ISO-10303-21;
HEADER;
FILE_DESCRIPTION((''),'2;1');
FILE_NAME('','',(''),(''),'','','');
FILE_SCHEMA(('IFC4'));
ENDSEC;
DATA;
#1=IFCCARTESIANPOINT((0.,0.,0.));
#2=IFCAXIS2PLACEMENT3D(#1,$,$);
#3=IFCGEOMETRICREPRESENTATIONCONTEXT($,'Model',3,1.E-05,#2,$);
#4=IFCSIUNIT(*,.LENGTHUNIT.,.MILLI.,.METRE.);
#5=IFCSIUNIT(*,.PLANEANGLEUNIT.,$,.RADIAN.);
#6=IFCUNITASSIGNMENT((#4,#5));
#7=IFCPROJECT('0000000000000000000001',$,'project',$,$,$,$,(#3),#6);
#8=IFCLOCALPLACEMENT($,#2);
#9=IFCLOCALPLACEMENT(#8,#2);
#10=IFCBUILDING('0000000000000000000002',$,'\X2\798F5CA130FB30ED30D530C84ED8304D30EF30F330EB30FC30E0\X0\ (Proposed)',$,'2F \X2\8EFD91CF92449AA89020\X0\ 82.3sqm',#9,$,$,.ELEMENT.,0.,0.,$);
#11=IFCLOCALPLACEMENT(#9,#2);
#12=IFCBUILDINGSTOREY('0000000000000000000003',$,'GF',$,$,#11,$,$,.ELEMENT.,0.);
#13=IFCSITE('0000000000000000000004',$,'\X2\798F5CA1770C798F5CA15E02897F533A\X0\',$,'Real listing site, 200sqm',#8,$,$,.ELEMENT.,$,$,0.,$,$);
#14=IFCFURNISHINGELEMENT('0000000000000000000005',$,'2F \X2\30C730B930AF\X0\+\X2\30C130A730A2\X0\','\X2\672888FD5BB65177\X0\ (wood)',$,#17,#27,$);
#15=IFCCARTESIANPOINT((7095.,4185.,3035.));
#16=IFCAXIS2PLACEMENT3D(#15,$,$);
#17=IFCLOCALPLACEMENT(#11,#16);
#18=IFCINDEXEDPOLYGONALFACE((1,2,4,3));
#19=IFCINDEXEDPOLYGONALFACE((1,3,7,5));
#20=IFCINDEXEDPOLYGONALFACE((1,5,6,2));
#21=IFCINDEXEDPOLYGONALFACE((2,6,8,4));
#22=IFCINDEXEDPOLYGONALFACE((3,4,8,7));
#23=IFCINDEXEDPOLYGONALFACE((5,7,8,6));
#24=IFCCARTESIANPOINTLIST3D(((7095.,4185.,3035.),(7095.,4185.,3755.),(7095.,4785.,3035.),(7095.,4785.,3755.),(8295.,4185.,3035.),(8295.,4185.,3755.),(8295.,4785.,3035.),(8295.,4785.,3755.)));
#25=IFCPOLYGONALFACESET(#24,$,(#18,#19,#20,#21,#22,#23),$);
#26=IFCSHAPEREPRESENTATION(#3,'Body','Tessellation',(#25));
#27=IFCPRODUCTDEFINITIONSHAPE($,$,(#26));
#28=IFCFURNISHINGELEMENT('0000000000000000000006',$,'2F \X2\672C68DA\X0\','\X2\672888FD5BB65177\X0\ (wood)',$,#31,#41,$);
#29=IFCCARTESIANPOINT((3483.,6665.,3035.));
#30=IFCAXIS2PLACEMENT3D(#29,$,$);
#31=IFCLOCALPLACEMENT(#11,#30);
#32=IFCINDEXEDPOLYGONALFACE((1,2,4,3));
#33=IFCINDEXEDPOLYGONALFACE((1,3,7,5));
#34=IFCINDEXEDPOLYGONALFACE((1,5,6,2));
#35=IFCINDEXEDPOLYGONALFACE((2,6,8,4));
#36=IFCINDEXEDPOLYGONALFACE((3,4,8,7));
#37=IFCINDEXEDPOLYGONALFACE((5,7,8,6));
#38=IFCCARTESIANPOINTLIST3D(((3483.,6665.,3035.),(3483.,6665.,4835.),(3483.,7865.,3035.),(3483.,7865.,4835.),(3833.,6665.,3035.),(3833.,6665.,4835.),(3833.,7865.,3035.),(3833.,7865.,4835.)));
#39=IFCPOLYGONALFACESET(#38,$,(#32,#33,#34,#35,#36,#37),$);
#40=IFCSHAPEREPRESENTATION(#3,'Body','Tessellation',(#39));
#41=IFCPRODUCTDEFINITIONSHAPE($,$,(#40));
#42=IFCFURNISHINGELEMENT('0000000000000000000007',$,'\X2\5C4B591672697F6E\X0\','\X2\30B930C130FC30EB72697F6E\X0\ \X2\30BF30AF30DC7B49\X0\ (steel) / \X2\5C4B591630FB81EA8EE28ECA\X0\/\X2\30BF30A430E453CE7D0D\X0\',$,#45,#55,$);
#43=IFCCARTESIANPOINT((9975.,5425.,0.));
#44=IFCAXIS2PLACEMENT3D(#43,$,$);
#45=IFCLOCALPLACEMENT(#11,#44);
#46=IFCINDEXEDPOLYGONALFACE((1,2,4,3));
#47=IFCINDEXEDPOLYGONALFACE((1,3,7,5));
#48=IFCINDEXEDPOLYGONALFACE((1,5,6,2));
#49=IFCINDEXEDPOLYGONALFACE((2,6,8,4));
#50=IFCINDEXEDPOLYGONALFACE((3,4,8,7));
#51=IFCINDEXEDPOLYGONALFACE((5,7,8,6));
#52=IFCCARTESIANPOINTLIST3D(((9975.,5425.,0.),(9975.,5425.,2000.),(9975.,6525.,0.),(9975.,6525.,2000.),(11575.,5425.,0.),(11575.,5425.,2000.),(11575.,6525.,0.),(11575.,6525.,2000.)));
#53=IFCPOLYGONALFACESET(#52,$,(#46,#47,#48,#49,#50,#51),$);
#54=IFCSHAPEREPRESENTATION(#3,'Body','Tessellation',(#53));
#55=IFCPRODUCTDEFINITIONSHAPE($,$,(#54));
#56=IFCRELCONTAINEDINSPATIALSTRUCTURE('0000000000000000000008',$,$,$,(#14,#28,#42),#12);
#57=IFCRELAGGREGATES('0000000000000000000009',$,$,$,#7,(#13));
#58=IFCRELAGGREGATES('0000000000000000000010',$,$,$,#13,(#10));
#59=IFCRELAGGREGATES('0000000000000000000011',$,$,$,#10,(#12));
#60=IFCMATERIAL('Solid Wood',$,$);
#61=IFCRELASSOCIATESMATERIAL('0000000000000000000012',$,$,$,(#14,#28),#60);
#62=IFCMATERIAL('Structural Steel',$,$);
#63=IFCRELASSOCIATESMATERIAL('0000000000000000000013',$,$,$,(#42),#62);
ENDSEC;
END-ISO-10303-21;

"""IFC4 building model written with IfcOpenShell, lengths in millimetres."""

from ifc_helpers import new_model, si_unit, frame, frame_2d, origin, place, context, project, spatial, rectangle, extrude, material, element, save


model = new_model("IFC4")

# Units and contexts
model_context = context("Model", 3, precision=1e-05, world=origin())
ifc_project = project(units=[si_unit("LENGTHUNIT", "METRE", prefix="MILLI"), si_unit("PLANEANGLEUNIT", "RADIAN")], contexts=[model_context])

# Site, building, storey
site_placement = place(None, origin())
site = spatial("IfcSite", under=ifc_project, at=site_placement, Name="福岡県福岡市西区", ObjectType="Real listing site, 200sqm", CompositionType="ELEMENT", RefElevation=0.0)
building_placement = place(site_placement, origin())
building = spatial("IfcBuilding", under=site, at=building_placement, Name="福岡・ロフト付きワンルーム (Proposed)", ObjectType="2F 軽量鉄骨造 82.3sqm", CompositionType="ELEMENT", ElevationOfRefHeight=0.0, ElevationOfTerrain=0.0)
storey_placement = place(building_placement, origin())
storey = spatial("IfcBuildingStorey", under=building, at=storey_placement, Name="GF", CompositionType="ELEMENT", Elevation=0.0)

# Shared definitions
ifc_material_1 = material(Name="Solid Wood")

# Shared definitions
ifc_material_2 = material(Name="Structural Steel")

# Furnishing elements
furnishing_1_placement = place(storey_placement, frame((7095.0, 4185.0, 3035.0)))
element("IfcFurnishingElement", 1, at=furnishing_1_placement, inside=storey, material=ifc_material_1, Name="2F デスク+チェア", Description="木製家具 (wood)", context=model_context, shape_type="SweptSolid", body=[
    extrude(rectangle(XDim=1200.0, YDim=600.0, at=frame_2d((600.0, 300.0))), frame((7095.0, 4185.0, 3035.0)), (0.0, 0.0, 1.0), 720.0),
])
furnishing_2_placement = place(storey_placement, frame((3483.0, 6665.0, 3035.0)))
element("IfcFurnishingElement", 2, at=furnishing_2_placement, inside=storey, material=ifc_material_1, Name="2F 本棚", Description="木製家具 (wood)", context=model_context, shape_type="SweptSolid", body=[
    extrude(rectangle(XDim=350.0, YDim=1200.0, at=frame_2d((175.0, 600.0))), frame((3483.0, 6665.0, 3035.0)), (0.0, 0.0, 1.0), 1800.0),
])
furnishing_3_placement = place(storey_placement, frame((9975.0, 5425.0, 0.0)))
element("IfcFurnishingElement", 3, at=furnishing_3_placement, inside=storey, material=ifc_material_2, Name="屋外物置", Description="スチール物置 タクボ等 (steel) / 屋外・自転車/タイヤ収納", context=model_context, shape_type="SweptSolid", body=[
    extrude(rectangle(XDim=1600.0, YDim=1100.0, at=frame_2d((800.0, 550.0))), frame((9975.0, 5425.0, 0.0)), (0.0, 0.0, 1.0), 2000.0),
])

save(model, "model.ifc")
